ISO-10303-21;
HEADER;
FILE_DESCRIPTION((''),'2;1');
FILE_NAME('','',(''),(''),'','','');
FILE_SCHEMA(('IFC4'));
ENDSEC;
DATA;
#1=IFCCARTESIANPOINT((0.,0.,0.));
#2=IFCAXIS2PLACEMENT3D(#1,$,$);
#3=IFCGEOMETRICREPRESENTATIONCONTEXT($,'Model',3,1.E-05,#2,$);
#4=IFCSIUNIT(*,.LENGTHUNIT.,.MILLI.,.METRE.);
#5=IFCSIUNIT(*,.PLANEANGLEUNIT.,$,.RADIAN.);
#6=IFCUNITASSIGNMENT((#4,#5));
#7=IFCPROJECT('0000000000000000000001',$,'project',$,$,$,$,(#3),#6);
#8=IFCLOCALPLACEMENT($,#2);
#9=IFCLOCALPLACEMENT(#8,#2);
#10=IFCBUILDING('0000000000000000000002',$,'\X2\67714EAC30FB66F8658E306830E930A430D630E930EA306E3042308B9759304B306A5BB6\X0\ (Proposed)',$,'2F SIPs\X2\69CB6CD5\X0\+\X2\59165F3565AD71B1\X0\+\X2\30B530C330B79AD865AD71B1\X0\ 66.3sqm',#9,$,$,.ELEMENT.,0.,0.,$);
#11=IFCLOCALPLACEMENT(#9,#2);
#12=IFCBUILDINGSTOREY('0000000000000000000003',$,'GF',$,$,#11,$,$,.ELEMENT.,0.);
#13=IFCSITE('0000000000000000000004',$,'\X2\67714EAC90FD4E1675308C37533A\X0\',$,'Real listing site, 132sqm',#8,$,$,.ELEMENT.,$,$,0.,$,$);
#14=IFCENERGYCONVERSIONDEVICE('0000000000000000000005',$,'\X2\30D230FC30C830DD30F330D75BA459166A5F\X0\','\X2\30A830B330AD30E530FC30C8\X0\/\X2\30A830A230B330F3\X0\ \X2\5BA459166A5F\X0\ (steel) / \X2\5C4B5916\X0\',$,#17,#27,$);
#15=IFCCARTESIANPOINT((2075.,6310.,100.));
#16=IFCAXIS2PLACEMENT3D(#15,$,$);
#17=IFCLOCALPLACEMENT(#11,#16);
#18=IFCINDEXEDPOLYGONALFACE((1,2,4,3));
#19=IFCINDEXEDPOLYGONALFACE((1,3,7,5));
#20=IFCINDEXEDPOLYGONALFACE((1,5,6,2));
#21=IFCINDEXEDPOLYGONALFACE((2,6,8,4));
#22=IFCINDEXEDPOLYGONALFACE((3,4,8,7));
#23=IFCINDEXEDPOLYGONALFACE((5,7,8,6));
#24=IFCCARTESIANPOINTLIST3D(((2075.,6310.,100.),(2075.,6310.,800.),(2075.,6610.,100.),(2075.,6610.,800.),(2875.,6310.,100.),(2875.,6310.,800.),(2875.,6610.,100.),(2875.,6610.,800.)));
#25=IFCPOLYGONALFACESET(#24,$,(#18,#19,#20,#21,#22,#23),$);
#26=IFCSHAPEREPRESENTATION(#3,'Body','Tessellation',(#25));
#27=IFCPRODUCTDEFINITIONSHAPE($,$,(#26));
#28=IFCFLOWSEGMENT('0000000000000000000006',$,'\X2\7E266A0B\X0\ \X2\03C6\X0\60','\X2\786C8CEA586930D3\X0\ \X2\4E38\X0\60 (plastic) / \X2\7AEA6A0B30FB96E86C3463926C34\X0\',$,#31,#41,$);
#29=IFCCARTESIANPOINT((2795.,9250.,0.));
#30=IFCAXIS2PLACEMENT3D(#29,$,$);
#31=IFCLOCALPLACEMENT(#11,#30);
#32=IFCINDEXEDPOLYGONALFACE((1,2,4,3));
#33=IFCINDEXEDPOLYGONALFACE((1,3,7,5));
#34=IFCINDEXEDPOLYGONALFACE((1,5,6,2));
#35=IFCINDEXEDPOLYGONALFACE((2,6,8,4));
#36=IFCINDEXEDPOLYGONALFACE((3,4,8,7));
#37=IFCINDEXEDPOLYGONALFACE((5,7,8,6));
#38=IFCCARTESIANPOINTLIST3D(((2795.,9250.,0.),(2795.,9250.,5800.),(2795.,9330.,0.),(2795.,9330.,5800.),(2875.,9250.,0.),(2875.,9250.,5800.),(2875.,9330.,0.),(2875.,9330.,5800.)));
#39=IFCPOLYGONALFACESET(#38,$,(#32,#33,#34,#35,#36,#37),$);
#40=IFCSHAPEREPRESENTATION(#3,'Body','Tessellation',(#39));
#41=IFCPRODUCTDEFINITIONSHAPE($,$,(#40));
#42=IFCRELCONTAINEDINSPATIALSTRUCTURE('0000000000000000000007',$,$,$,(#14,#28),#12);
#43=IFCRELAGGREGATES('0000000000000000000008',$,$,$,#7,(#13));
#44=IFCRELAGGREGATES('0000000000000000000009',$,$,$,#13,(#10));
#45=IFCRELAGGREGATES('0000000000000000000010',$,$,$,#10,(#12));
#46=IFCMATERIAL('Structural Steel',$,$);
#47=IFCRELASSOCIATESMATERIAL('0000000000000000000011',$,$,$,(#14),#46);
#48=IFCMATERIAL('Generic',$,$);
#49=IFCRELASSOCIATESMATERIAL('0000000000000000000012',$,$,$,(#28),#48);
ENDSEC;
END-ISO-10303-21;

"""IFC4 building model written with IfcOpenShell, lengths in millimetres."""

from ifc_helpers import new_model, si_unit, frame, frame_2d, origin, place, context, project, spatial, rectangle, extrude, material, element, save


model = new_model("IFC4")

# Units and contexts
model_context = context("Model", 3, precision=1e-05, world=origin())
ifc_project = project(units=[si_unit("LENGTHUNIT", "METRE", prefix="MILLI"), si_unit("PLANEANGLEUNIT", "RADIAN")], contexts=[model_context])

# Site, building, storey
site_placement = place(None, origin())
site = spatial("IfcSite", under=ifc_project, at=site_placement, Name="東京都世田谷区", ObjectType="Real listing site, 132sqm", CompositionType="ELEMENT", RefElevation=0.0)
building_placement = place(site_placement, origin())
building = spatial("IfcBuilding", under=site, at=building_placement, Name="東京・書斎とライブラリのある静かな家 (Proposed)", ObjectType="2F SIPs構法+外張断熱+サッシ高断熱 66.3sqm", CompositionType="ELEMENT", ElevationOfRefHeight=0.0, ElevationOfTerrain=0.0)
storey_placement = place(building_placement, origin())
storey = spatial("IfcBuildingStorey", under=building, at=storey_placement, Name="GF", CompositionType="ELEMENT", Elevation=0.0)

# Shared definitions
ifc_material_1 = material(Name="Generic")

# Energy conversion device
ifc_material_2 = material(Name="Structural Steel")
energy_conversion_device_placement = place(storey_placement, frame((2075.0, 6310.0, 100.0)))
element("IfcEnergyConversionDevice", 1, at=energy_conversion_device_placement, inside=storey, material=ifc_material_2, Name="ヒートポンプ室外機", Description="エコキュート/エアコン 室外機 (steel) / 屋外", context=model_context, shape_type="SweptSolid", body=[
    extrude(rectangle(XDim=800.0, YDim=300.0, at=frame_2d((400.0, 150.0))), frame((2075.0, 6310.0, 100.0)), (0.0, 0.0, 1.0), 700.0),
])

# Flow segment
flow_segment_placement = place(storey_placement, frame((2795.0, 9250.0, 0.0)))
element("IfcFlowSegment", 2, at=flow_segment_placement, inside=storey, material=ifc_material_1, Name="縦樋 φ60", Description="硬質塩ビ 丸60 (plastic) / 竪樋・雨水排水", context=model_context, shape_type="SweptSolid", body=[
    extrude(rectangle(XDim=80.0, YDim=80.0, at=frame_2d((40.0, 40.0))), frame((2795.0, 9250.0, 0.0)), (0.0, 0.0, 1.0), 5800.0),
])

save(model, "model.ifc")
